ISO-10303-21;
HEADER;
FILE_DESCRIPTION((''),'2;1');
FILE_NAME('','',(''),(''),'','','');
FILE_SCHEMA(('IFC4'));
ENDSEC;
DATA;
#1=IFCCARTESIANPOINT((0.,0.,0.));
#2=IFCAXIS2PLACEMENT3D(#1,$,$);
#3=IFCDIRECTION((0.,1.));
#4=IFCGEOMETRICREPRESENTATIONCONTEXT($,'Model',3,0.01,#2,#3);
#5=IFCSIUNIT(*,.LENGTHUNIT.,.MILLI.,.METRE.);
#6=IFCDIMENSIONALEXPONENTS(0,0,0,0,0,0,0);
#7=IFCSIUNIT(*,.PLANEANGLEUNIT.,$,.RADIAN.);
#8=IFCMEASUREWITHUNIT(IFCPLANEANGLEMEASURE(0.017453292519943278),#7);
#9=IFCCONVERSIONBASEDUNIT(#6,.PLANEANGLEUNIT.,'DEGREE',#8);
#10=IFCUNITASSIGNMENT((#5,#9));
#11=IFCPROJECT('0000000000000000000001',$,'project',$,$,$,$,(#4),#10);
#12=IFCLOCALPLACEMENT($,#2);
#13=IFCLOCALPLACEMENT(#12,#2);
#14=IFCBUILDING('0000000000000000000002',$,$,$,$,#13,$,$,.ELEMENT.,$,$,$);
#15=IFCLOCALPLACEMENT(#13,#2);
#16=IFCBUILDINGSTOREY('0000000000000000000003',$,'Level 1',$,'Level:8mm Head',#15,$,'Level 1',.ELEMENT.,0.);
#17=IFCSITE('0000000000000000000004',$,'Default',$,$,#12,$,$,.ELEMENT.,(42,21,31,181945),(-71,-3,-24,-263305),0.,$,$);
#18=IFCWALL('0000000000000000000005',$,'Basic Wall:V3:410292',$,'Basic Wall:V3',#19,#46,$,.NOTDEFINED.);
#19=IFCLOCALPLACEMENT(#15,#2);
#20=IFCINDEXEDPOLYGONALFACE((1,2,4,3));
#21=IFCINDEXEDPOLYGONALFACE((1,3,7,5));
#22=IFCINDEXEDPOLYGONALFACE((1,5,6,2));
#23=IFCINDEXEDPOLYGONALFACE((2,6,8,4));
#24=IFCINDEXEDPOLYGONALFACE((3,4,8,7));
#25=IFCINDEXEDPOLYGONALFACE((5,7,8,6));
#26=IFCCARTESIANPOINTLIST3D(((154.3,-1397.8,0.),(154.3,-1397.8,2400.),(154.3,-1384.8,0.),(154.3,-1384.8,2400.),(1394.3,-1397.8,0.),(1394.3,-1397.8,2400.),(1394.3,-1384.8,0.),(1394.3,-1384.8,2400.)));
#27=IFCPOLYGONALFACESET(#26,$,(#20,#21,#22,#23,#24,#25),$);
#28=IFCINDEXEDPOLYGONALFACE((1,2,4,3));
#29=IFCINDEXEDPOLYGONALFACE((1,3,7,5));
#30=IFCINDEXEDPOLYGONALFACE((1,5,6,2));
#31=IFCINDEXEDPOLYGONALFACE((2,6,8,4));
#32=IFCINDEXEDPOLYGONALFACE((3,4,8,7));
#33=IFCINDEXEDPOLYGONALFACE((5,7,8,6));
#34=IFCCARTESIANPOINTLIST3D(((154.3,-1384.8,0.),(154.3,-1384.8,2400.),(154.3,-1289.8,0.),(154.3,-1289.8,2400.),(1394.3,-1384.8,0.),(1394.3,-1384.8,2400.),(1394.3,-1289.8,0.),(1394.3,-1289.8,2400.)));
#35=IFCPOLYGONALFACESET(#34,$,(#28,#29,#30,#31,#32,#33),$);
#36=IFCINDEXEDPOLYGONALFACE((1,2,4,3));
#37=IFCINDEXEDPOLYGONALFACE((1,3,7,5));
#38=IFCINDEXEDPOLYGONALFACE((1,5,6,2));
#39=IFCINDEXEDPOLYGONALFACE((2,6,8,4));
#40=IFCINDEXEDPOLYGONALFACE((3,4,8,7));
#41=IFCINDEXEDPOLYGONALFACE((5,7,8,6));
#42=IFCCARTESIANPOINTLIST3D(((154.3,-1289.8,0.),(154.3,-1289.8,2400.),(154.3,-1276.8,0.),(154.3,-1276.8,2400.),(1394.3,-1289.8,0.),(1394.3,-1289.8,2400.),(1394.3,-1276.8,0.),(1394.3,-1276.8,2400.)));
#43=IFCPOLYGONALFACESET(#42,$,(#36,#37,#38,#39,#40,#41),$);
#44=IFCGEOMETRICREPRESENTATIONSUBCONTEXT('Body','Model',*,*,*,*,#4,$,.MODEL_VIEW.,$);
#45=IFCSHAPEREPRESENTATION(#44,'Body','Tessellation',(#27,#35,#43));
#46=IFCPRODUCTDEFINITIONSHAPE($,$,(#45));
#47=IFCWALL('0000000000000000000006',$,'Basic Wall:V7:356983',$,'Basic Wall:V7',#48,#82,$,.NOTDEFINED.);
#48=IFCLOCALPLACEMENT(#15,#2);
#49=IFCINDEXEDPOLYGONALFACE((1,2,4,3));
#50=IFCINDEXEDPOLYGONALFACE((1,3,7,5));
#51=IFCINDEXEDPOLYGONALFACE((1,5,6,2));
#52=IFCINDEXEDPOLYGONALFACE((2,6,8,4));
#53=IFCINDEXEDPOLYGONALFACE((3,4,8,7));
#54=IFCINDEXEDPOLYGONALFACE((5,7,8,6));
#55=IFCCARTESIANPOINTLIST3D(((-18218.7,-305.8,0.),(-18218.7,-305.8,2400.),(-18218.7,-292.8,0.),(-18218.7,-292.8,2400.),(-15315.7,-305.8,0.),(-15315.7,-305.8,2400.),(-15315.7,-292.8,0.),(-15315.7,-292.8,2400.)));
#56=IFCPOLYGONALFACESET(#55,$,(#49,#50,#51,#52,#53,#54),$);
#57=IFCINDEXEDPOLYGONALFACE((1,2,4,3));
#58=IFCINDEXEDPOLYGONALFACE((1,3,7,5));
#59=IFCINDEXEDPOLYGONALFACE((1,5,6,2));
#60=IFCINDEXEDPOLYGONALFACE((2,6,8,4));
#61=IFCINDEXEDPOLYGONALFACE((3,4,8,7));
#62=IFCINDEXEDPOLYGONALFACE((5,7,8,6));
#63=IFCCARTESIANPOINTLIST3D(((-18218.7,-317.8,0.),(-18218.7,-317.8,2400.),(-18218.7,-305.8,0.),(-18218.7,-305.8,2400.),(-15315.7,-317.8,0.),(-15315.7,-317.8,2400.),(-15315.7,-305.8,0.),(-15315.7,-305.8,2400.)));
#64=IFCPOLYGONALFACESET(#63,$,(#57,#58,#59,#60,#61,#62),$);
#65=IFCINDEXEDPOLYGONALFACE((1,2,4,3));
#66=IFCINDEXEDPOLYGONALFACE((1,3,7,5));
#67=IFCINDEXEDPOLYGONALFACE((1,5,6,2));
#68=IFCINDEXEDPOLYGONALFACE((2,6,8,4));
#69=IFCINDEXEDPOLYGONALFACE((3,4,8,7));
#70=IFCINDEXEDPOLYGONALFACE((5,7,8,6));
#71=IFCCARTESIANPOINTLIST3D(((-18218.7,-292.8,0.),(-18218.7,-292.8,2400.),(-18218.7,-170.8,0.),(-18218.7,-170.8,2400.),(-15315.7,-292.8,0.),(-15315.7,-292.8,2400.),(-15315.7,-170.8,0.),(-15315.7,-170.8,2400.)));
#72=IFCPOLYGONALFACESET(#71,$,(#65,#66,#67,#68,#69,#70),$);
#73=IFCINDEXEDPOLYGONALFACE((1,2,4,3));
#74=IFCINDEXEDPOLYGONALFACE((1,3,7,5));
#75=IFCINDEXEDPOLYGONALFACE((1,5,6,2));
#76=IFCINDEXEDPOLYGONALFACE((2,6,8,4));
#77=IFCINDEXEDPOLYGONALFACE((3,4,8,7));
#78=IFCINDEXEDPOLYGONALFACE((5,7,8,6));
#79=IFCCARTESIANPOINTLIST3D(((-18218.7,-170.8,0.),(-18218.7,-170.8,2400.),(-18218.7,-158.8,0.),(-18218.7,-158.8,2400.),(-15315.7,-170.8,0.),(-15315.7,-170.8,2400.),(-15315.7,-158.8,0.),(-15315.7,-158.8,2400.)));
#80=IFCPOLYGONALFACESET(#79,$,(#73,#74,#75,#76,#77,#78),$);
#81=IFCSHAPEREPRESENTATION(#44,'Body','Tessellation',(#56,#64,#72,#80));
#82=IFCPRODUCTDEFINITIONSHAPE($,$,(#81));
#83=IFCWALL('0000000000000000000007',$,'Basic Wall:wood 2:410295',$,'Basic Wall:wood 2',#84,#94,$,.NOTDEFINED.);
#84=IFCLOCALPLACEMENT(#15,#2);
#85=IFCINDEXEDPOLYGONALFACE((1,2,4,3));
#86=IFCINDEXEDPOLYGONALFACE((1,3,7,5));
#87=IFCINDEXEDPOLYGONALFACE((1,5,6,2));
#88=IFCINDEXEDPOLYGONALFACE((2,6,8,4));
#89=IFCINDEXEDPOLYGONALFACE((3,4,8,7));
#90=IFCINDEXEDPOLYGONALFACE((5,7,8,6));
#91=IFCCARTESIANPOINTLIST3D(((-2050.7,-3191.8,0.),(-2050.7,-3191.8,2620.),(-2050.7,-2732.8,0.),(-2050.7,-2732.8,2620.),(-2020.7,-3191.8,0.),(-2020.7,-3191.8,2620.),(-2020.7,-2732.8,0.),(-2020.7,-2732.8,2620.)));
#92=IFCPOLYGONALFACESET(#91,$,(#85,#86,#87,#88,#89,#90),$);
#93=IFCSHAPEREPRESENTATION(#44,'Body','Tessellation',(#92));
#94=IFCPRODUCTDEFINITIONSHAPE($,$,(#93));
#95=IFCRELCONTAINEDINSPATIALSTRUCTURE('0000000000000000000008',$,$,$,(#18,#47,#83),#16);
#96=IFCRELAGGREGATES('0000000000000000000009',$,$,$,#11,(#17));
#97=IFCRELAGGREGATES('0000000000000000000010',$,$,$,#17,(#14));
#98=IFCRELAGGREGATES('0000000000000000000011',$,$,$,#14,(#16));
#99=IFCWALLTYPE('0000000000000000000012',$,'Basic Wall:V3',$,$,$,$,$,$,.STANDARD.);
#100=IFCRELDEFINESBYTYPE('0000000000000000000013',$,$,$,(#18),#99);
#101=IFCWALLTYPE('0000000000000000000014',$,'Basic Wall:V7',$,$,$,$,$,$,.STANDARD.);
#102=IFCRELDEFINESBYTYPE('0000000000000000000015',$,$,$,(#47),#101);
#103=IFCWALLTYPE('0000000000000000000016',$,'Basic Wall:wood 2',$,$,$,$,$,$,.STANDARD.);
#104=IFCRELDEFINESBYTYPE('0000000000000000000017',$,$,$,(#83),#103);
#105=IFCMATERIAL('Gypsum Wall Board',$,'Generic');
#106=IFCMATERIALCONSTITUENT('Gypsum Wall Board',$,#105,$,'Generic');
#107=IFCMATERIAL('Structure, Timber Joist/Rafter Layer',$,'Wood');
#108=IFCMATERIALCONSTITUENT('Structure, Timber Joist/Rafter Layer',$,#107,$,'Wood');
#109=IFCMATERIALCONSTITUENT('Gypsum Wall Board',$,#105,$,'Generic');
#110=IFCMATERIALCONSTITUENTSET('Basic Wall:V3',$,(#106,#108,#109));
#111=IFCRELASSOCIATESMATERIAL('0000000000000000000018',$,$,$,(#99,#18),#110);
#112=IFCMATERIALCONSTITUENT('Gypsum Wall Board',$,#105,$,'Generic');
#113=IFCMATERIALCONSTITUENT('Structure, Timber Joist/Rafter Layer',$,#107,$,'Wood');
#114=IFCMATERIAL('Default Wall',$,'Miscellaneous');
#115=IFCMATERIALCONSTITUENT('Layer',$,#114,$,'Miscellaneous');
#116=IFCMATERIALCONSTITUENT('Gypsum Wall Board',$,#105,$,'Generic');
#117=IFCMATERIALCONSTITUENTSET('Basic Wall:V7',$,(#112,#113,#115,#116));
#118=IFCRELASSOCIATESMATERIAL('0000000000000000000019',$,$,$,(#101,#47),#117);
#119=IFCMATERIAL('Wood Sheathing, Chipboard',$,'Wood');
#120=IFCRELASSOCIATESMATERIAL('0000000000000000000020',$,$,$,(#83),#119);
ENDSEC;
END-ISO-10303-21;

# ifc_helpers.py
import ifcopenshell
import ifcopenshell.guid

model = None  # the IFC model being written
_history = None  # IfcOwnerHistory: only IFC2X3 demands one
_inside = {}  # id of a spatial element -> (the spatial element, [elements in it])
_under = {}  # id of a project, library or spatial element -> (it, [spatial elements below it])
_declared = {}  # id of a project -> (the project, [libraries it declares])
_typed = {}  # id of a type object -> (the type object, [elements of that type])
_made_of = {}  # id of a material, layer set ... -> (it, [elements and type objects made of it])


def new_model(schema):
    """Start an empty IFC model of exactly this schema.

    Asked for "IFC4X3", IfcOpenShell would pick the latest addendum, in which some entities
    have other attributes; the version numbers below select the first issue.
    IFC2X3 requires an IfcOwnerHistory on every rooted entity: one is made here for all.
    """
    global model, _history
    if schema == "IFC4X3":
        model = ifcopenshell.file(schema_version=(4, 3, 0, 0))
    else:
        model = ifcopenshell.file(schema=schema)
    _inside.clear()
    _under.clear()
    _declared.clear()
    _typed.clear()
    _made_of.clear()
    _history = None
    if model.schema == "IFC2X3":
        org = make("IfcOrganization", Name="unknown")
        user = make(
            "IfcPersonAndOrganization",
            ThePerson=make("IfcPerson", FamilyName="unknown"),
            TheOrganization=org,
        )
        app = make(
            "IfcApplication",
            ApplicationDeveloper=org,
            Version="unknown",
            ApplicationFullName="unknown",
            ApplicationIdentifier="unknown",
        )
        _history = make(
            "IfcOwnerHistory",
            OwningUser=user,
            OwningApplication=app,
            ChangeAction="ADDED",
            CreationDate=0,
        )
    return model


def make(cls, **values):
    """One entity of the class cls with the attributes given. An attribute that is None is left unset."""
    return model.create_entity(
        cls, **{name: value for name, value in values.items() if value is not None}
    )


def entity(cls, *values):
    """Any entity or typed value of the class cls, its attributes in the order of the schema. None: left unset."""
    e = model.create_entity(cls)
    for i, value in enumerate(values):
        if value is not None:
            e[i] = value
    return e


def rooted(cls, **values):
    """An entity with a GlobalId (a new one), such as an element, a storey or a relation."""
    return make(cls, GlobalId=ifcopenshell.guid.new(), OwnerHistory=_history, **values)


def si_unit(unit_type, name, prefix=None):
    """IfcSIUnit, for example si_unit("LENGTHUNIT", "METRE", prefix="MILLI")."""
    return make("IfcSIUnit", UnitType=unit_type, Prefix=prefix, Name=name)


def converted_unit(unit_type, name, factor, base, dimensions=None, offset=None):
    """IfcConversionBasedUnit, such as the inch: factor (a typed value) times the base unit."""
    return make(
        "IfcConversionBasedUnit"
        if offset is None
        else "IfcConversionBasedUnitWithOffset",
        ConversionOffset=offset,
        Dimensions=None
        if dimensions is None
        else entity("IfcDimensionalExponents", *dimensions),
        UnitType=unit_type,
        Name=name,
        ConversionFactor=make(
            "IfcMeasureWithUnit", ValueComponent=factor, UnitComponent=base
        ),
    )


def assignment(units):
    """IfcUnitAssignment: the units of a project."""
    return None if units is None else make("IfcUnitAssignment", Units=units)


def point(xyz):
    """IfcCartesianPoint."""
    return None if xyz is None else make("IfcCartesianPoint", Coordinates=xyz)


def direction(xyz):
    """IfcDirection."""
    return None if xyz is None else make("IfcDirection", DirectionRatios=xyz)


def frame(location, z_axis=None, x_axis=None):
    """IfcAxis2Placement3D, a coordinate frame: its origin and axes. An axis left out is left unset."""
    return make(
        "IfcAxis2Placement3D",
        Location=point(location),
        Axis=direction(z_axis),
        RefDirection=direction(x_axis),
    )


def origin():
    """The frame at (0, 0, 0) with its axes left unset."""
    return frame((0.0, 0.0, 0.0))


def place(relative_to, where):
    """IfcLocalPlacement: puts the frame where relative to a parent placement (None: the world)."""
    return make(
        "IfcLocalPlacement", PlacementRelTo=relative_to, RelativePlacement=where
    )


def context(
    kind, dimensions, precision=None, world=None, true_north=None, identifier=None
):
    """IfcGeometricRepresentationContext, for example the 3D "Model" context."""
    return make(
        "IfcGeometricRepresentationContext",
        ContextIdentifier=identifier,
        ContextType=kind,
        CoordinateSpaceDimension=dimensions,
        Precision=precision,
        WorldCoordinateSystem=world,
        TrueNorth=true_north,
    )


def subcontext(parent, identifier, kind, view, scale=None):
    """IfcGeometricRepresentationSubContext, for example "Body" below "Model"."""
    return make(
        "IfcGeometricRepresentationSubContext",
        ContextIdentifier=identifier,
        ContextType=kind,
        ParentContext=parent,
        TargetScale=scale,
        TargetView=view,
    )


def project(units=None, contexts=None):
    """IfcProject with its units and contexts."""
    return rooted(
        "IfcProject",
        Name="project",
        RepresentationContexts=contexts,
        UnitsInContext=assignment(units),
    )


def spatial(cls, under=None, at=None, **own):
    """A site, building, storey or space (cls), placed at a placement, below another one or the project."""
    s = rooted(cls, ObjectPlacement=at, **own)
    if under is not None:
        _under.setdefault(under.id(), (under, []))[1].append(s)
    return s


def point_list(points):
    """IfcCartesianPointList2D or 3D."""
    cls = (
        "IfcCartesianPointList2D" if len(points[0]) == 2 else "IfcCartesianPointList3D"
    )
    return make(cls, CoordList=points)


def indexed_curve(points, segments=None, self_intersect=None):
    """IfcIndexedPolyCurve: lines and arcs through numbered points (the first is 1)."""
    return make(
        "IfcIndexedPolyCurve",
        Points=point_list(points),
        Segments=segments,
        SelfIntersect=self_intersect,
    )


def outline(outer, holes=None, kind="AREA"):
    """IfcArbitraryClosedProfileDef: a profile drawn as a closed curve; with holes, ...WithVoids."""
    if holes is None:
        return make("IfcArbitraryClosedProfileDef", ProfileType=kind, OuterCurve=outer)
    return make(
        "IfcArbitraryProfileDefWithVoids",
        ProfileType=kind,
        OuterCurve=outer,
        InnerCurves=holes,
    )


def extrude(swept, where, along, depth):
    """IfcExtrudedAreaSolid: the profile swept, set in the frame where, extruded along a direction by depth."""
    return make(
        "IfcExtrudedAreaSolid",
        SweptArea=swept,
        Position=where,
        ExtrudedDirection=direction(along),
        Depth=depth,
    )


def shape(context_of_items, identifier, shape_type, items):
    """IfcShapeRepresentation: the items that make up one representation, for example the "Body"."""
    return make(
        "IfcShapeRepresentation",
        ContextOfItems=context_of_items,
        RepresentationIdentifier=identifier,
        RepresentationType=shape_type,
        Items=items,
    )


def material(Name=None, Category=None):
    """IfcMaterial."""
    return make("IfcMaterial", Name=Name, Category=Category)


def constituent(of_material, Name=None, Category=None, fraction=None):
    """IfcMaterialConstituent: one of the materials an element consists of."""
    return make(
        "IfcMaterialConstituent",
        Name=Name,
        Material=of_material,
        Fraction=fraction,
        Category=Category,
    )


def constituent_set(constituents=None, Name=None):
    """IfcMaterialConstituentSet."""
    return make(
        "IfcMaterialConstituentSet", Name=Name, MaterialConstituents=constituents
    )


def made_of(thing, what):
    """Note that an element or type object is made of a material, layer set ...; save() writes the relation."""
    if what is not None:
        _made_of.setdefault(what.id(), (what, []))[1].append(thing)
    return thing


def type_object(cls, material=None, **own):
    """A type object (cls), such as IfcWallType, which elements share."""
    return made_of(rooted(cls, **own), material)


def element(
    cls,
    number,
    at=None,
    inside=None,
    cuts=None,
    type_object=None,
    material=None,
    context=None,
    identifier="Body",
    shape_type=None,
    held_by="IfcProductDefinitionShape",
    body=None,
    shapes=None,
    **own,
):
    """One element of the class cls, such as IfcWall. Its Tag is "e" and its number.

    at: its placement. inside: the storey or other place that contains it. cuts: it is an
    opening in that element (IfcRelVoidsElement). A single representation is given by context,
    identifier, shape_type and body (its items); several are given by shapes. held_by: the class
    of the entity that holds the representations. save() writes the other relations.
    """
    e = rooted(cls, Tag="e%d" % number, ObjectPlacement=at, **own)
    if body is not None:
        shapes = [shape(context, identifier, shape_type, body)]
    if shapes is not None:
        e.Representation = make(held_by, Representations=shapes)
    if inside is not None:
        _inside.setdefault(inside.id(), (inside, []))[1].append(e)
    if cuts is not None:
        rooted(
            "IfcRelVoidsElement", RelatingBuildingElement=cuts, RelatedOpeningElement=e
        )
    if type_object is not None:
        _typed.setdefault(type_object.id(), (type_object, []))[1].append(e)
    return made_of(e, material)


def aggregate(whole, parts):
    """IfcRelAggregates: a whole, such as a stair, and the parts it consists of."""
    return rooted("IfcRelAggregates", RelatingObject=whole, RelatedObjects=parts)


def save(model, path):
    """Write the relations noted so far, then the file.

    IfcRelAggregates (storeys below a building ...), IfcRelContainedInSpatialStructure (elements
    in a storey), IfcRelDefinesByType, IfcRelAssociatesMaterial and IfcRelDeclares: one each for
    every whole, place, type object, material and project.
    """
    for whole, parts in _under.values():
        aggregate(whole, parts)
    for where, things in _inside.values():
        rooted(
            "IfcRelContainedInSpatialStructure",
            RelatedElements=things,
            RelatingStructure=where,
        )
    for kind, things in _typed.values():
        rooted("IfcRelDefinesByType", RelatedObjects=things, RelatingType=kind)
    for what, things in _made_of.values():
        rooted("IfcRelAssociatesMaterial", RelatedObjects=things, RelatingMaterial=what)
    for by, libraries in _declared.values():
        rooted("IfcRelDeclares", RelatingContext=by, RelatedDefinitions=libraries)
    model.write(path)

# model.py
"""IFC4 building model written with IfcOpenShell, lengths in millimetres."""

from ifc_helpers import new_model, entity, si_unit, converted_unit, direction, frame, origin, place, context, subcontext, project, spatial, indexed_curve, outline, extrude, material, constituent, constituent_set, type_object, element, save


model = new_model("IFC4")

# Units and contexts
model_context = context("Model", 3, precision=0.01, world=origin(), true_north=direction((0.0, 1.0)))
body_context = subcontext(model_context, "Body", "Model", "MODEL_VIEW")
ifc_project = project(units=[si_unit("LENGTHUNIT", "METRE", prefix="MILLI"), converted_unit("PLANEANGLEUNIT", "DEGREE", entity("IfcPlaneAngleMeasure", 0.017453292519943278), si_unit("PLANEANGLEUNIT", "RADIAN"), dimensions=[0, 0, 0, 0, 0, 0, 0])], contexts=[model_context])

# Site, building, storey
site_placement = place(None, origin())
site = spatial("IfcSite", under=ifc_project, at=site_placement, Name="Default", CompositionType="ELEMENT", RefLatitude=(42, 21, 31, 181945), RefLongitude=(-71, -3, -24, -263305), RefElevation=0.0)
building_placement = place(site_placement, origin())
building = spatial("IfcBuilding", under=site, at=building_placement, CompositionType="ELEMENT")
storey_placement = place(building_placement, origin())
storey = spatial("IfcBuildingStorey", under=building, at=storey_placement, Name="Level 1", ObjectType="Level:8mm Head", LongName="Level 1", CompositionType="ELEMENT", Elevation=0.0)

# Shared definitions
ifc_material_1 = material(Name="Gypsum Wall Board", Category="Generic")
ifc_material_2 = material(Name="Structure, Timber Joist/Rafter Layer", Category="Wood")

# Walls
ifc_constituent_1 = constituent(ifc_material_1, Name="Gypsum Wall Board", Category="Generic")
ifc_constituent_2 = constituent(ifc_material_2, Name="Structure, Timber Joist/Rafter Layer", Category="Wood")
ifc_constituent_3 = constituent(ifc_material_1, Name="Gypsum Wall Board", Category="Generic")
ifc_constituent_set_1 = constituent_set(constituents=[ifc_constituent_1, ifc_constituent_2, ifc_constituent_3], Name="Basic Wall:V3")
wall_type_1 = type_object("IfcWallType", Name="Basic Wall:V3", PredefinedType="STANDARD", material=ifc_constituent_set_1)
wall_1_placement = place(storey_placement, frame((154.3, -1337.3, 0.0)))
element("IfcWall", 1, at=wall_1_placement, inside=storey, type_object=wall_type_1, material=ifc_constituent_set_1, Name="Basic Wall:V3:410292", ObjectType="Basic Wall:V3", PredefinedType="NOTDEFINED", context=body_context, shape_type="SweptSolid", body=[
    extrude(outline(indexed_curve([(-6.5, -620.0), (6.5, -620.0), (6.5, 620.0), (-6.5, 620.0), (-6.5, -620.0)], self_intersect=False)), frame((620.0, -54.0, 0.0), z_axis=(0.0, 0.0, 1.0), x_axis=(0.0, 1.0, 0.0)), (0.0, 0.0, 1.0), 2400.0),
    extrude(outline(indexed_curve([(-620.0, -47.5), (620.0, -47.5), (620.0, 47.5), (-620.0, 47.5), (-620.0, -47.5)], self_intersect=False)), frame((620.0, 0.0, 0.0)), (0.0, 0.0, 1.0), 2400.0),
    extrude(outline(indexed_curve([(-6.5, -620.0), (6.5, -620.0), (6.5, 620.0), (-6.5, 620.0), (-6.5, -620.0)], self_intersect=False)), frame((620.0, 54.0, 0.0), z_axis=(0.0, 0.0, 1.0), x_axis=(0.0, -1.0, 0.0)), (0.0, 0.0, 1.0), 2400.0),
])
ifc_constituent_4 = constituent(ifc_material_1, Name="Gypsum Wall Board", Category="Generic")
ifc_constituent_5 = constituent(ifc_material_2, Name="Structure, Timber Joist/Rafter Layer", Category="Wood")
ifc_material_3 = material(Name="Default Wall", Category="Miscellaneous")
ifc_constituent_6 = constituent(ifc_material_3, Name="Layer", Category="Miscellaneous")
ifc_constituent_7 = constituent(ifc_material_1, Name="Gypsum Wall Board", Category="Generic")
ifc_constituent_set_2 = constituent_set(constituents=[ifc_constituent_4, ifc_constituent_5, ifc_constituent_6, ifc_constituent_7], Name="Basic Wall:V7")
wall_type_2 = type_object("IfcWallType", Name="Basic Wall:V7", PredefinedType="STANDARD", material=ifc_constituent_set_2)
wall_2_placement = place(storey_placement, frame((-18218.7, -238.3, 0.0)))
element("IfcWall", 2, at=wall_2_placement, inside=storey, type_object=wall_type_2, material=ifc_constituent_set_2, Name="Basic Wall:V7:356983", ObjectType="Basic Wall:V7", PredefinedType="NOTDEFINED", context=body_context, shape_type="SweptSolid", body=[
    extrude(outline(indexed_curve([(-1451.5, -6.5), (1451.5, -6.5), (1451.5, 6.5), (-1451.5, 6.5), (-1451.5, -6.5)], self_intersect=False)), frame((1451.5, -61.0, 0.0)), (0.0, 0.0, 1.0), 2400.0),
    extrude(outline(indexed_curve([(-6.0, -1451.5), (6.0, -1451.5), (6.0, 1451.5), (-6.0, 1451.5), (-6.0, -1451.5)], self_intersect=False)), frame((1451.5, -73.5, 0.0), z_axis=(0.0, 0.0, 1.0), x_axis=(0.0, 1.0, 0.0)), (0.0, 0.0, 1.0), 2400.0),
    extrude(outline(indexed_curve([(-1451.5, -61.0), (1451.5, -61.0), (1451.5, 61.0), (-1451.5, 61.0), (-1451.5, -61.0)], self_intersect=False)), frame((1451.5, 6.5, 0.0)), (0.0, 0.0, 1.0), 2400.0),
    extrude(outline(indexed_curve([(-6.0, -1451.5), (6.0, -1451.5), (6.0, 1451.5), (-6.0, 1451.5), (-6.0, -1451.5)], self_intersect=False)), frame((1451.5, 73.5, 0.0), z_axis=(0.0, 0.0, 1.0), x_axis=(0.0, -1.0, 0.0)), (0.0, 0.0, 1.0), 2400.0),
])
ifc_material_4 = material(Name="Wood Sheathing, Chipboard", Category="Wood")
wall_type_3 = type_object("IfcWallType", Name="Basic Wall:wood 2", PredefinedType="STANDARD")
wall_3_placement = place(storey_placement, frame((-2035.7, -3191.8, 0.0), z_axis=(0.0, 0.0, 1.0), x_axis=(0.0, 1.0, 0.0)))
element("IfcWall", 3, at=wall_3_placement, inside=storey, type_object=wall_type_3, material=ifc_material_4, Name="Basic Wall:wood 2:410295", ObjectType="Basic Wall:wood 2", PredefinedType="NOTDEFINED", context=body_context, shape_type="SweptSolid", body=[
    extrude(outline(indexed_curve([(459.0, 15.0), (0.0, 15.0), (0.0, -15.0), (459.0, -15.0), (459.0, 15.0)], self_intersect=False)), origin(), (0.0, 0.0, 1.0), 2620.0),
])

save(model, "model.ifc")
